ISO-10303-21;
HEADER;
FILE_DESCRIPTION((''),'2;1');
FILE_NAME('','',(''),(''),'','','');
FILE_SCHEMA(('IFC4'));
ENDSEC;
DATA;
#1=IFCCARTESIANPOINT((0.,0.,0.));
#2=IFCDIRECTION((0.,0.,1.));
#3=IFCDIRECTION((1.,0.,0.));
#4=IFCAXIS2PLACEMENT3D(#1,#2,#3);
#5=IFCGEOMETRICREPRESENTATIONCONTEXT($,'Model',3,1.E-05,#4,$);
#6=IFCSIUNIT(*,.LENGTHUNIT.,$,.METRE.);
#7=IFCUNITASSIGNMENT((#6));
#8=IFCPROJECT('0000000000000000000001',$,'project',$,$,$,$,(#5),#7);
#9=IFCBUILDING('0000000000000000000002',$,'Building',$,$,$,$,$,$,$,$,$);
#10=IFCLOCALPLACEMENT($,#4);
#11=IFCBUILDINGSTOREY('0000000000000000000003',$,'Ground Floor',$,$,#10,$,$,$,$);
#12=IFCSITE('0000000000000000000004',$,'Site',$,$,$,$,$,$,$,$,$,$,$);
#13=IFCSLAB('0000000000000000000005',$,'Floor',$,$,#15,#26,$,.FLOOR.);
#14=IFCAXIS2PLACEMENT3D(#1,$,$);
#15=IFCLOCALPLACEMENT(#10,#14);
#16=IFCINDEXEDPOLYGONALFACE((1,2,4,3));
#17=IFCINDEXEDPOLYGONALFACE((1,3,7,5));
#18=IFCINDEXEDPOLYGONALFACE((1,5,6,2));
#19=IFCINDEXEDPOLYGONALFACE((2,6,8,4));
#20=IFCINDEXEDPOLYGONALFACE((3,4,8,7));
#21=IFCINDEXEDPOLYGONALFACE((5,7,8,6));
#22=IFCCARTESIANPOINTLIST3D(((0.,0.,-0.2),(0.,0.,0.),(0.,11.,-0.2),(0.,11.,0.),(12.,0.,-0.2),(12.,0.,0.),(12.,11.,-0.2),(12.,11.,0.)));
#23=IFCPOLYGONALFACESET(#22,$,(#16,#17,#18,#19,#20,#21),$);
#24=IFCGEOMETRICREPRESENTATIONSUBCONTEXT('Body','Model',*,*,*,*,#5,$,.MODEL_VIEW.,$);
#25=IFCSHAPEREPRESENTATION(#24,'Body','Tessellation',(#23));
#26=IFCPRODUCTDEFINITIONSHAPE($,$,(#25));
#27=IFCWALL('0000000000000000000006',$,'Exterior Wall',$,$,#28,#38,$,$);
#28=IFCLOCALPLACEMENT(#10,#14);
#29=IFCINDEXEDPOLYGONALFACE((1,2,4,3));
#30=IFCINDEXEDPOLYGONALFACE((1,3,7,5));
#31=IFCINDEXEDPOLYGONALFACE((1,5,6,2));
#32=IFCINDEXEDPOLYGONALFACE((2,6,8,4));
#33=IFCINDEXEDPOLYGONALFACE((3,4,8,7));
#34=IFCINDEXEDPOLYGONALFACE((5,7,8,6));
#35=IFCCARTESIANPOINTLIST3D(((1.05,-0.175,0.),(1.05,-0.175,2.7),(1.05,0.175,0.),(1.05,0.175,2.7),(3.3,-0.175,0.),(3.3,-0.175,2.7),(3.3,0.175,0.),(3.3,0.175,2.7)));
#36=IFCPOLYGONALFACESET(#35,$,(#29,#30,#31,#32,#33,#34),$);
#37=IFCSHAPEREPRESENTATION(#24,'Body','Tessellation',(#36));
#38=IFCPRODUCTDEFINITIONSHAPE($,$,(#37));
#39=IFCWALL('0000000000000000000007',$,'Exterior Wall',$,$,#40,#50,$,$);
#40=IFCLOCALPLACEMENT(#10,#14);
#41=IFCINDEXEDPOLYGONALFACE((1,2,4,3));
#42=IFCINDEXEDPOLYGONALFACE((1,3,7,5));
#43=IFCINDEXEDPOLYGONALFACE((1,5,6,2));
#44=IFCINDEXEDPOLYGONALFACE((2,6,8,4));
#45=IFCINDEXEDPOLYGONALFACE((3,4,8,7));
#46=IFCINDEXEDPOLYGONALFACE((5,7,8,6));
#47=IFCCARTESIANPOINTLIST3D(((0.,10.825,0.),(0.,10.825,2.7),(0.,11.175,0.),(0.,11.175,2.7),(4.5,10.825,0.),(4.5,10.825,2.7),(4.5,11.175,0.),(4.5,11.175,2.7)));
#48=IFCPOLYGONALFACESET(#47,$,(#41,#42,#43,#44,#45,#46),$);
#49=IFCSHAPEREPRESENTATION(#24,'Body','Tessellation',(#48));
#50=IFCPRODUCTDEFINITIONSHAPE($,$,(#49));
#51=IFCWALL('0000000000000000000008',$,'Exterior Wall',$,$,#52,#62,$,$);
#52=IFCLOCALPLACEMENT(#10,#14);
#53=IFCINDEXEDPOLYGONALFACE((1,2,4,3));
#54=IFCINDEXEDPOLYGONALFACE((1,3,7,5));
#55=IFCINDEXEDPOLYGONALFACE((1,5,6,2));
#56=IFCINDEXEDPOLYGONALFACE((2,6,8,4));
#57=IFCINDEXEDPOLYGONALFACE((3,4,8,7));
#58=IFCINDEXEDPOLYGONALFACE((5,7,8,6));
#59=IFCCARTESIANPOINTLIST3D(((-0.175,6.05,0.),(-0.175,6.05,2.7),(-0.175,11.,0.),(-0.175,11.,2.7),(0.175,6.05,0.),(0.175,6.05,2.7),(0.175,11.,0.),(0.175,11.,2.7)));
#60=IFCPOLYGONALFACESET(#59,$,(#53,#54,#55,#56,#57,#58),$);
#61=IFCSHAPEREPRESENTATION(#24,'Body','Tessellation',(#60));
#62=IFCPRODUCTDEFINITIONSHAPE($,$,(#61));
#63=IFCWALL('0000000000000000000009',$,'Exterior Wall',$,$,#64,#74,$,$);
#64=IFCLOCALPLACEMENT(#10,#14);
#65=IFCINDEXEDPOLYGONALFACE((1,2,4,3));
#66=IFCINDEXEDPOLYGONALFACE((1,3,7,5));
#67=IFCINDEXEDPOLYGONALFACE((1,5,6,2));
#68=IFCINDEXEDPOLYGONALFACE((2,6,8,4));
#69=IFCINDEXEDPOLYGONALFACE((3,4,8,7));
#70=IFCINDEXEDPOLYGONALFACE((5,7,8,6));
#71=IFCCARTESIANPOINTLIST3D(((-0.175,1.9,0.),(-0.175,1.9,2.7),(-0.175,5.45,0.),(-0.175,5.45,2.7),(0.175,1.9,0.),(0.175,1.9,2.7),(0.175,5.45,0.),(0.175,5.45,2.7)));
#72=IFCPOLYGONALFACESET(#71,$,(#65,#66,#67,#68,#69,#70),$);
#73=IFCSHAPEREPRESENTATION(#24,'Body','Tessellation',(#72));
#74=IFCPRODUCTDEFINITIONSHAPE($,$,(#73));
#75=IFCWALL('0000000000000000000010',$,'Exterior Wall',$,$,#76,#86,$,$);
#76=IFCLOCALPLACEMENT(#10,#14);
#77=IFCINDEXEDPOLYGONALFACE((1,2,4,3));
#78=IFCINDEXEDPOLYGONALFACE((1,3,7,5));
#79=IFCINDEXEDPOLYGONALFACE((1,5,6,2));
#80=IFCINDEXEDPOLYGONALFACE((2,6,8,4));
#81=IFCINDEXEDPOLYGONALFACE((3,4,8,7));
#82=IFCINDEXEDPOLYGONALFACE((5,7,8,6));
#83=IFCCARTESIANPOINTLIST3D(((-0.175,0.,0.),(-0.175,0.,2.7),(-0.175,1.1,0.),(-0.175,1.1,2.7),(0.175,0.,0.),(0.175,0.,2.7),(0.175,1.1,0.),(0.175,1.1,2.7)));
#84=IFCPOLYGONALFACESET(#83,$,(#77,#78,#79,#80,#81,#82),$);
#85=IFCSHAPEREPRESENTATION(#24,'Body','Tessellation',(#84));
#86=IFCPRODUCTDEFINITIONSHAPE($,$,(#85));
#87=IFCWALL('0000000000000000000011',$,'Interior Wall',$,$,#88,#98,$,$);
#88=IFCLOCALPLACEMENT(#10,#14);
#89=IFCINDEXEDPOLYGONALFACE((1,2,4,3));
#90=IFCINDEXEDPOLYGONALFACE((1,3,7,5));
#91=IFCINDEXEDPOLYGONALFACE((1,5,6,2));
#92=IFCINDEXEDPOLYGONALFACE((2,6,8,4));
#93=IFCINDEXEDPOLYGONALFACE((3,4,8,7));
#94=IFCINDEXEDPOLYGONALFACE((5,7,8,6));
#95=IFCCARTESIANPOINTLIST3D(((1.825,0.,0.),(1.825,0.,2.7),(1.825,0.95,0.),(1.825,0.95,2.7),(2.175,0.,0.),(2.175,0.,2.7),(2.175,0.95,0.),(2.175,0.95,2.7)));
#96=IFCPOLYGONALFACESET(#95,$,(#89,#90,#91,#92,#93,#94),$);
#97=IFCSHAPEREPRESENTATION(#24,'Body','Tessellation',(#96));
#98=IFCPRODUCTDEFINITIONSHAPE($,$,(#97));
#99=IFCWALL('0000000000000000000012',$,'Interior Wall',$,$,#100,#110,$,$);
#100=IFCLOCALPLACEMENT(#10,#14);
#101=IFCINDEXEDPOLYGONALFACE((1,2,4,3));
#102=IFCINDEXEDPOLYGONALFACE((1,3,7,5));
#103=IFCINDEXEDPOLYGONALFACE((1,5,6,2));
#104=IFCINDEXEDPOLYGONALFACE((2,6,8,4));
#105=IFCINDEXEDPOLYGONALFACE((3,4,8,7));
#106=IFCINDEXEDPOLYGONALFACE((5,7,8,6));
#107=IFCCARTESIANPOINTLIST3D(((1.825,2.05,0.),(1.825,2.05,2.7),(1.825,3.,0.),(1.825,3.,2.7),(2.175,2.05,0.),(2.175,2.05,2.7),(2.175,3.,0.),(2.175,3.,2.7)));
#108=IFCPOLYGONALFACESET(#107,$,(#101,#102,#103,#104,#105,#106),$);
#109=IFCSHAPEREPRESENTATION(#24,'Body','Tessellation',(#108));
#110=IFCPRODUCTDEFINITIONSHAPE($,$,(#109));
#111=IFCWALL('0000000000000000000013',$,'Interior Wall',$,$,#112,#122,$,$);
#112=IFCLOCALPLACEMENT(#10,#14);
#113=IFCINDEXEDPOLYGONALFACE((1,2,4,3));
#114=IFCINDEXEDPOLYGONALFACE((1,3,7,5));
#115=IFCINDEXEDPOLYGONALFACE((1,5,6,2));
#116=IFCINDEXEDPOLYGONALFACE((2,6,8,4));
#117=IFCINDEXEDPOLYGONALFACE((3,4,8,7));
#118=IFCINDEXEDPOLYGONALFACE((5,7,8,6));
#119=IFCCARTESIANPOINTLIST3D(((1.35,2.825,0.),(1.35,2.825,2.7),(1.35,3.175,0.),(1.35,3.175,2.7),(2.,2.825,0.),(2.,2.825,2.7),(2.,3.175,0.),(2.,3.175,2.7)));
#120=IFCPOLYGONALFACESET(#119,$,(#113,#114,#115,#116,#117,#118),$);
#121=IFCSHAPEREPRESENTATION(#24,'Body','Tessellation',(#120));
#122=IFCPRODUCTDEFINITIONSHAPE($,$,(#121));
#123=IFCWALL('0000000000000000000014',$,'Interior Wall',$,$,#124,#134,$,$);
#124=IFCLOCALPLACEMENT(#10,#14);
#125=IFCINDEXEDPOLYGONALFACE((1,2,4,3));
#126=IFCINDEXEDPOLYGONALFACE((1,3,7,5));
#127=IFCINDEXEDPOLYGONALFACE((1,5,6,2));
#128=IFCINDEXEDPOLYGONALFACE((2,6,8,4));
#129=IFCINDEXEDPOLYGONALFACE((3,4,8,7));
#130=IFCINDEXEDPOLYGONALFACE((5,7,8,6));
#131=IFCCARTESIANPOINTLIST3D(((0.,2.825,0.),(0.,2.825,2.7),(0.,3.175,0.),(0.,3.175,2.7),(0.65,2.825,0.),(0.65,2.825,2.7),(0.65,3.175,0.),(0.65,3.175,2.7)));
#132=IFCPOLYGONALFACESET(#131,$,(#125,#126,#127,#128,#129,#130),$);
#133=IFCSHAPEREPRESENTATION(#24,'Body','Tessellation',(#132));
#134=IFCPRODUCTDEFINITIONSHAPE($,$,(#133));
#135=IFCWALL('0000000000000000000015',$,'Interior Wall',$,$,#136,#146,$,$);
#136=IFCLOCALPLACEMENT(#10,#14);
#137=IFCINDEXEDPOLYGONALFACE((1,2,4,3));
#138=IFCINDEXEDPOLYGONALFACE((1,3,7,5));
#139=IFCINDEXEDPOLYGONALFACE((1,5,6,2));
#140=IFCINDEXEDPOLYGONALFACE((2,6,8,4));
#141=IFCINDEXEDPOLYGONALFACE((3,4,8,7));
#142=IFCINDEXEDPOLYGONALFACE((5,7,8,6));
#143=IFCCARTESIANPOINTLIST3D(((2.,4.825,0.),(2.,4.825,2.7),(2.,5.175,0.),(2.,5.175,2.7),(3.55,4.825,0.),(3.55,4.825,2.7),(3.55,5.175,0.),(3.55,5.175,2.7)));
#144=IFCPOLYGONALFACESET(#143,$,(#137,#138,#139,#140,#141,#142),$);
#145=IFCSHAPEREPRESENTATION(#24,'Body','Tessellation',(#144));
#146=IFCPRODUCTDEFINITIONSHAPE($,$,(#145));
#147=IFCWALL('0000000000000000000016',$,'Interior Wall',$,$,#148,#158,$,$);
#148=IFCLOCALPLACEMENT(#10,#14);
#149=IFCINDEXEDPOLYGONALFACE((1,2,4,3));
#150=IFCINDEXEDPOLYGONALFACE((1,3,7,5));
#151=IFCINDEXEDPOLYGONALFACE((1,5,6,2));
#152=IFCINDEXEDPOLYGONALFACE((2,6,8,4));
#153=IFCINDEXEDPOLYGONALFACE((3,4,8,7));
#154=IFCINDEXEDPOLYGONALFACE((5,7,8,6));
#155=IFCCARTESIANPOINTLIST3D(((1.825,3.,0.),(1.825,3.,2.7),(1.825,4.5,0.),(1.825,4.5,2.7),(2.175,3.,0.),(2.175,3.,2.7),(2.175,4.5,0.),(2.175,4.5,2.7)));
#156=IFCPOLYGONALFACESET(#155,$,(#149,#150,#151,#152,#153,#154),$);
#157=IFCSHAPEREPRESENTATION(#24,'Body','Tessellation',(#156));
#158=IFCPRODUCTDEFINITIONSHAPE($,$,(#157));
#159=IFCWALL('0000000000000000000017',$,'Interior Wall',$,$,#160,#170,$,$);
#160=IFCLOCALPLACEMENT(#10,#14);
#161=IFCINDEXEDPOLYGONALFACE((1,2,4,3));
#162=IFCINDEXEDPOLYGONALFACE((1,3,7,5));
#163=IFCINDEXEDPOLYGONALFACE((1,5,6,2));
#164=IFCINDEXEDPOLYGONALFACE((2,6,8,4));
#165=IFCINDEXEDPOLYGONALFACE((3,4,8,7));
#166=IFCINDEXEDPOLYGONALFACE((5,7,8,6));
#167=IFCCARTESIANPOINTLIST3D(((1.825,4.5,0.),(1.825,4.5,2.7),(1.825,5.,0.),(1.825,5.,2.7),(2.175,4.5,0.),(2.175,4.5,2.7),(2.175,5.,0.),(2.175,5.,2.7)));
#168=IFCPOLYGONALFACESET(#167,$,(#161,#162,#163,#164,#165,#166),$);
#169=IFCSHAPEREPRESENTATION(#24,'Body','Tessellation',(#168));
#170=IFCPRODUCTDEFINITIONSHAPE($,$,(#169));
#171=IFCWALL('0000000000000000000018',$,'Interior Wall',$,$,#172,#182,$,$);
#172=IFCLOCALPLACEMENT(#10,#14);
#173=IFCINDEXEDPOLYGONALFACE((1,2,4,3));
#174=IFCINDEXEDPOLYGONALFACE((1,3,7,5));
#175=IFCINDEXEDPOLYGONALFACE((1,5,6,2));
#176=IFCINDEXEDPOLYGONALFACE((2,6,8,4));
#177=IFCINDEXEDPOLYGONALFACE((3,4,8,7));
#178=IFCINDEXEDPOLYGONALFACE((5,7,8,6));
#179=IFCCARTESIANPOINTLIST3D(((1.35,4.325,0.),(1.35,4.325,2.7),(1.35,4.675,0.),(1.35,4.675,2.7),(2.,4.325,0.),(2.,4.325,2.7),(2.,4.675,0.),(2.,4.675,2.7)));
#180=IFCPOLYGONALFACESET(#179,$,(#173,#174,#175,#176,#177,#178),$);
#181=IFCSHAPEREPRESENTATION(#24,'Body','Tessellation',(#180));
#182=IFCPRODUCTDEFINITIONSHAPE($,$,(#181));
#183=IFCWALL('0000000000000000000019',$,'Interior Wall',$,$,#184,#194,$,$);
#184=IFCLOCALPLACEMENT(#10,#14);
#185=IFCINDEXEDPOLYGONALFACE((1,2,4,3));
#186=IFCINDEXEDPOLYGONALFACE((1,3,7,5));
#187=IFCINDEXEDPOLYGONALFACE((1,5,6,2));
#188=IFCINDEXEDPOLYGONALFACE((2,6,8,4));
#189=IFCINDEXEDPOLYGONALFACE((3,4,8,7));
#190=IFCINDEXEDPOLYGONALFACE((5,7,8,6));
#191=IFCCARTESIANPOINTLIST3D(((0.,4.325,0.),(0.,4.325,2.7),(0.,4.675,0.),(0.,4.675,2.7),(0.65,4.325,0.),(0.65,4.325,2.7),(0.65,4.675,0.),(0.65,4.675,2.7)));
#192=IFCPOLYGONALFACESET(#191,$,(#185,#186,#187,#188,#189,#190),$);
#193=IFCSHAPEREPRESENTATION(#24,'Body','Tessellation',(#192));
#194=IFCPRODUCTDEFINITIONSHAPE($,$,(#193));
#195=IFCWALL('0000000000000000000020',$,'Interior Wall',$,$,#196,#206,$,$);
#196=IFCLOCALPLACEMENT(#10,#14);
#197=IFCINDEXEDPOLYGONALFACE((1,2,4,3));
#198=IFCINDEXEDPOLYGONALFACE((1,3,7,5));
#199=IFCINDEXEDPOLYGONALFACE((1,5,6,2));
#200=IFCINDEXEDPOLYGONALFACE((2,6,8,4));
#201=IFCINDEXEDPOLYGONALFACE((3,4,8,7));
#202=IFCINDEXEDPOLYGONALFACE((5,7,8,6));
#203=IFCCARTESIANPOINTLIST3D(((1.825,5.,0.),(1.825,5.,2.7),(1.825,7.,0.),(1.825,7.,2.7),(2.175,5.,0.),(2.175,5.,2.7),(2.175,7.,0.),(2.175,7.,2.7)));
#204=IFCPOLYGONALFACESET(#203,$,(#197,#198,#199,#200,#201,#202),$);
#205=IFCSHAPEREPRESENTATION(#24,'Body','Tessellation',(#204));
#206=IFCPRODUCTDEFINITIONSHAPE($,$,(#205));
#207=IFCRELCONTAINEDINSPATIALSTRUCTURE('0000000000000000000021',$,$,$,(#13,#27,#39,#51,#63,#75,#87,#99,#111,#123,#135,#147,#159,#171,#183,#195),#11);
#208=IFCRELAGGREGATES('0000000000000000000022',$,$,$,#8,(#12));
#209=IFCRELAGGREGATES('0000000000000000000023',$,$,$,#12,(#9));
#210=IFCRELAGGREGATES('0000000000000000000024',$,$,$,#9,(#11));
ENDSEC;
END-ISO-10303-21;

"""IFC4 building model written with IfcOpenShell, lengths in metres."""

from ifc_helpers import new_model, si_unit, frame, origin_with_axes, place, context, subcontext, project, spatial, indexed_curve, outline, extrude, element, save


model = new_model("IFC4")

# Units and contexts
model_context = context("Model", 3, precision=1e-05, world=origin_with_axes())
body_context = subcontext(model_context, "Body", "Model", "MODEL_VIEW")
ifc_project = project(units=[si_unit("LENGTHUNIT", "METRE")], contexts=[model_context])

# Site, building, storey
site = spatial("IfcSite", under=ifc_project, Name="Site")
building = spatial("IfcBuilding", under=site, Name="Building")
storey_placement = place(None, origin_with_axes())
storey = spatial("IfcBuildingStorey", under=building, at=storey_placement, Name="Ground Floor")

# Slab
slab_placement = place(storey_placement, frame((0.0, 0.0, -0.2), z_axis=(0.0, 0.0, 1.0), x_axis=(1.0, 0.0, 0.0)))
element("IfcSlab", 1, at=slab_placement, inside=storey, Name="Floor", PredefinedType="FLOOR", context=body_context, shape_type="SweptSolid", body=[
    extrude(outline(indexed_curve([(0.0, 0.0), (12.0, 0.0), (12.0, 11.0), (0.0, 11.0)])), None, (0.0, 0.0, 1.0), 0.2),
])

# Walls
wall_1_placement = place(storey_placement, frame((1.05, 0.0, 0.0), z_axis=(0.0, 0.0, 1.0), x_axis=(1.0, 0.0, 0.0)))
element("IfcWall", 2, at=wall_1_placement, inside=storey, Name="Exterior Wall", context=body_context, shape_type="SweptSolid", body=[
    extrude(outline(indexed_curve([(0.0, 0.0), (0.0, 0.35), (2.25, 0.35), (2.25, 0.0), (0.0, 0.0)], self_intersect=False)), frame((0.0, -0.175, 0.0), z_axis=(0.0, 0.0, 1.0), x_axis=(1.0, 0.0, 0.0)), (0.0, 0.0, 1.0), 2.7),
])
wall_2_placement = place(storey_placement, frame((4.5, 11.0, 0.0), z_axis=(0.0, 0.0, 1.0), x_axis=(-1.0, 0.0, 0.0)))
element("IfcWall", 3, at=wall_2_placement, inside=storey, Name="Exterior Wall", context=body_context, shape_type="SweptSolid", body=[
    extrude(outline(indexed_curve([(0.0, 0.0), (0.0, 0.35), (4.5, 0.35), (4.5, 0.0), (0.0, 0.0)], self_intersect=False)), frame((0.0, -0.175, 0.0), z_axis=(0.0, 0.0, 1.0), x_axis=(1.0, 0.0, 0.0)), (0.0, 0.0, 1.0), 2.7),
])
wall_3_placement = place(storey_placement, frame((0.0, 11.0, 0.0), z_axis=(0.0, 0.0, 1.0), x_axis=(0.0, -1.0, 0.0)))
element("IfcWall", 4, at=wall_3_placement, inside=storey, Name="Exterior Wall", context=body_context, shape_type="SweptSolid", body=[
    extrude(outline(indexed_curve([(0.0, 0.0), (0.0, 0.35), (4.95, 0.35), (4.95, 0.0), (0.0, 0.0)], self_intersect=False)), frame((0.0, -0.175, 0.0), z_axis=(0.0, 0.0, 1.0), x_axis=(1.0, 0.0, 0.0)), (0.0, 0.0, 1.0), 2.7),
])
wall_4_placement = place(storey_placement, frame((0.0, 5.45, 0.0), z_axis=(0.0, 0.0, 1.0), x_axis=(0.0, -1.0, 0.0)))
element("IfcWall", 5, at=wall_4_placement, inside=storey, Name="Exterior Wall", context=body_context, shape_type="SweptSolid", body=[
    extrude(outline(indexed_curve([(0.0, 0.0), (0.0, 0.35), (3.55, 0.35), (3.55, 0.0), (0.0, 0.0)], self_intersect=False)), frame((0.0, -0.175, 0.0), z_axis=(0.0, 0.0, 1.0), x_axis=(1.0, 0.0, 0.0)), (0.0, 0.0, 1.0), 2.7),
])
wall_5_placement = place(storey_placement, frame((0.0, 1.1, 0.0), z_axis=(0.0, 0.0, 1.0), x_axis=(0.0, -1.0, 0.0)))
element("IfcWall", 6, at=wall_5_placement, inside=storey, Name="Exterior Wall", context=body_context, shape_type="SweptSolid", body=[
    extrude(outline(indexed_curve([(0.0, 0.0), (0.0, 0.35), (1.1, 0.35), (1.1, 0.0), (0.0, 0.0)], self_intersect=False)), frame((0.0, -0.175, 0.0), z_axis=(0.0, 0.0, 1.0), x_axis=(1.0, 0.0, 0.0)), (0.0, 0.0, 1.0), 2.7),
])
wall_6_placement = place(storey_placement, frame((2.0, 0.0, 0.0), z_axis=(0.0, 0.0, 1.0), x_axis=(0.0, 1.0, 0.0)))
element("IfcWall", 7, at=wall_6_placement, inside=storey, Name="Interior Wall", context=body_context, shape_type="SweptSolid", body=[
    extrude(outline(indexed_curve([(0.0, 0.0), (0.0, 0.35), (0.95, 0.35), (0.95, 0.0), (0.0, 0.0)], self_intersect=False)), frame((0.0, -0.175, 0.0), z_axis=(0.0, 0.0, 1.0), x_axis=(1.0, 0.0, 0.0)), (0.0, 0.0, 1.0), 2.7),
])
wall_7_placement = place(storey_placement, frame((2.0, 2.05, 0.0), z_axis=(0.0, 0.0, 1.0), x_axis=(0.0, 1.0, 0.0)))
element("IfcWall", 8, at=wall_7_placement, inside=storey, Name="Interior Wall", context=body_context, shape_type="SweptSolid", body=[
    extrude(outline(indexed_curve([(0.0, 0.0), (0.0, 0.35), (0.95, 0.35), (0.95, 0.0), (0.0, 0.0)], self_intersect=False)), frame((0.0, -0.175, 0.0), z_axis=(0.0, 0.0, 1.0), x_axis=(1.0, 0.0, 0.0)), (0.0, 0.0, 1.0), 2.7),
])
for number, where, z_axis, x_axis, name in (
    (9, (2.0, 3.0, 0.0), (0.0, 0.0, 1.0), (-1.0, 0.0, 0.0), "Interior Wall"),
    (10, (0.65, 3.0, 0.0), (0.0, 0.0, 1.0), (-1.0, 0.0, 0.0), "Interior Wall"),
):
    element("IfcWall", number, at=place(storey_placement, frame(where, z_axis=z_axis, x_axis=x_axis)), inside=storey, Name=name, context=body_context, shape_type="SweptSolid", body=[
        extrude(outline(indexed_curve([(0.0, 0.0), (0.0, 0.35), (0.65, 0.35), (0.65, 0.0), (0.0, 0.0)], self_intersect=False)), frame((0.0, -0.175, 0.0), z_axis=(0.0, 0.0, 1.0), x_axis=(1.0, 0.0, 0.0)), (0.0, 0.0, 1.0), 2.7),
    ])
wall_8_placement = place(storey_placement, frame((3.55, 5.0, 0.0), z_axis=(0.0, 0.0, 1.0), x_axis=(-1.0, 0.0, 0.0)))
element("IfcWall", 11, at=wall_8_placement, inside=storey, Name="Interior Wall", context=body_context, shape_type="SweptSolid", body=[
    extrude(outline(indexed_curve([(0.0, 0.0), (0.0, 0.35), (1.55, 0.35), (1.55, 0.0), (0.0, 0.0)], self_intersect=False)), frame((0.0, -0.175, 0.0), z_axis=(0.0, 0.0, 1.0), x_axis=(1.0, 0.0, 0.0)), (0.0, 0.0, 1.0), 2.7),
])
wall_9_placement = place(storey_placement, frame((2.0, 4.5, 0.0), z_axis=(0.0, 0.0, 1.0), x_axis=(0.0, -1.0, 0.0)))
element("IfcWall", 12, at=wall_9_placement, inside=storey, Name="Interior Wall", context=body_context, shape_type="SweptSolid", body=[
    extrude(outline(indexed_curve([(0.0, 0.0), (0.0, 0.35), (1.5, 0.35), (1.5, 0.0), (0.0, 0.0)], self_intersect=False)), frame((0.0, -0.175, 0.0), z_axis=(0.0, 0.0, 1.0), x_axis=(1.0, 0.0, 0.0)), (0.0, 0.0, 1.0), 2.7),
])
wall_10_placement = place(storey_placement, frame((2.0, 5.0, 0.0), z_axis=(0.0, 0.0, 1.0), x_axis=(0.0, -1.0, 0.0)))
element("IfcWall", 13, at=wall_10_placement, inside=storey, Name="Interior Wall", context=body_context, shape_type="SweptSolid", body=[
    extrude(outline(indexed_curve([(0.0, 0.0), (0.0, 0.35), (0.5, 0.35), (0.5, 0.0), (0.0, 0.0)], self_intersect=False)), frame((0.0, -0.175, 0.0), z_axis=(0.0, 0.0, 1.0), x_axis=(1.0, 0.0, 0.0)), (0.0, 0.0, 1.0), 2.7),
])
for number, where, z_axis, x_axis, name in (
    (14, (2.0, 4.5, 0.0), (0.0, 0.0, 1.0), (-1.0, 0.0, 0.0), "Interior Wall"),
    (15, (0.65, 4.5, 0.0), (0.0, 0.0, 1.0), (-1.0, 0.0, 0.0), "Interior Wall"),
):
    element("IfcWall", number, at=place(storey_placement, frame(where, z_axis=z_axis, x_axis=x_axis)), inside=storey, Name=name, context=body_context, shape_type="SweptSolid", body=[
        extrude(outline(indexed_curve([(0.0, 0.0), (0.0, 0.35), (0.65, 0.35), (0.65, 0.0), (0.0, 0.0)], self_intersect=False)), frame((0.0, -0.175, 0.0), z_axis=(0.0, 0.0, 1.0), x_axis=(1.0, 0.0, 0.0)), (0.0, 0.0, 1.0), 2.7),
    ])
wall_11_placement = place(storey_placement, frame((2.0, 5.0, 0.0), z_axis=(0.0, 0.0, 1.0), x_axis=(0.0, 1.0, 0.0)))
element("IfcWall", 16, at=wall_11_placement, inside=storey, Name="Interior Wall", context=body_context, shape_type="SweptSolid", body=[
    extrude(outline(indexed_curve([(0.0, 0.0), (0.0, 0.35), (2.0, 0.35), (2.0, 0.0), (0.0, 0.0)], self_intersect=False)), frame((0.0, -0.175, 0.0), z_axis=(0.0, 0.0, 1.0), x_axis=(1.0, 0.0, 0.0)), (0.0, 0.0, 1.0), 2.7),
])

save(model, "model.ifc")
